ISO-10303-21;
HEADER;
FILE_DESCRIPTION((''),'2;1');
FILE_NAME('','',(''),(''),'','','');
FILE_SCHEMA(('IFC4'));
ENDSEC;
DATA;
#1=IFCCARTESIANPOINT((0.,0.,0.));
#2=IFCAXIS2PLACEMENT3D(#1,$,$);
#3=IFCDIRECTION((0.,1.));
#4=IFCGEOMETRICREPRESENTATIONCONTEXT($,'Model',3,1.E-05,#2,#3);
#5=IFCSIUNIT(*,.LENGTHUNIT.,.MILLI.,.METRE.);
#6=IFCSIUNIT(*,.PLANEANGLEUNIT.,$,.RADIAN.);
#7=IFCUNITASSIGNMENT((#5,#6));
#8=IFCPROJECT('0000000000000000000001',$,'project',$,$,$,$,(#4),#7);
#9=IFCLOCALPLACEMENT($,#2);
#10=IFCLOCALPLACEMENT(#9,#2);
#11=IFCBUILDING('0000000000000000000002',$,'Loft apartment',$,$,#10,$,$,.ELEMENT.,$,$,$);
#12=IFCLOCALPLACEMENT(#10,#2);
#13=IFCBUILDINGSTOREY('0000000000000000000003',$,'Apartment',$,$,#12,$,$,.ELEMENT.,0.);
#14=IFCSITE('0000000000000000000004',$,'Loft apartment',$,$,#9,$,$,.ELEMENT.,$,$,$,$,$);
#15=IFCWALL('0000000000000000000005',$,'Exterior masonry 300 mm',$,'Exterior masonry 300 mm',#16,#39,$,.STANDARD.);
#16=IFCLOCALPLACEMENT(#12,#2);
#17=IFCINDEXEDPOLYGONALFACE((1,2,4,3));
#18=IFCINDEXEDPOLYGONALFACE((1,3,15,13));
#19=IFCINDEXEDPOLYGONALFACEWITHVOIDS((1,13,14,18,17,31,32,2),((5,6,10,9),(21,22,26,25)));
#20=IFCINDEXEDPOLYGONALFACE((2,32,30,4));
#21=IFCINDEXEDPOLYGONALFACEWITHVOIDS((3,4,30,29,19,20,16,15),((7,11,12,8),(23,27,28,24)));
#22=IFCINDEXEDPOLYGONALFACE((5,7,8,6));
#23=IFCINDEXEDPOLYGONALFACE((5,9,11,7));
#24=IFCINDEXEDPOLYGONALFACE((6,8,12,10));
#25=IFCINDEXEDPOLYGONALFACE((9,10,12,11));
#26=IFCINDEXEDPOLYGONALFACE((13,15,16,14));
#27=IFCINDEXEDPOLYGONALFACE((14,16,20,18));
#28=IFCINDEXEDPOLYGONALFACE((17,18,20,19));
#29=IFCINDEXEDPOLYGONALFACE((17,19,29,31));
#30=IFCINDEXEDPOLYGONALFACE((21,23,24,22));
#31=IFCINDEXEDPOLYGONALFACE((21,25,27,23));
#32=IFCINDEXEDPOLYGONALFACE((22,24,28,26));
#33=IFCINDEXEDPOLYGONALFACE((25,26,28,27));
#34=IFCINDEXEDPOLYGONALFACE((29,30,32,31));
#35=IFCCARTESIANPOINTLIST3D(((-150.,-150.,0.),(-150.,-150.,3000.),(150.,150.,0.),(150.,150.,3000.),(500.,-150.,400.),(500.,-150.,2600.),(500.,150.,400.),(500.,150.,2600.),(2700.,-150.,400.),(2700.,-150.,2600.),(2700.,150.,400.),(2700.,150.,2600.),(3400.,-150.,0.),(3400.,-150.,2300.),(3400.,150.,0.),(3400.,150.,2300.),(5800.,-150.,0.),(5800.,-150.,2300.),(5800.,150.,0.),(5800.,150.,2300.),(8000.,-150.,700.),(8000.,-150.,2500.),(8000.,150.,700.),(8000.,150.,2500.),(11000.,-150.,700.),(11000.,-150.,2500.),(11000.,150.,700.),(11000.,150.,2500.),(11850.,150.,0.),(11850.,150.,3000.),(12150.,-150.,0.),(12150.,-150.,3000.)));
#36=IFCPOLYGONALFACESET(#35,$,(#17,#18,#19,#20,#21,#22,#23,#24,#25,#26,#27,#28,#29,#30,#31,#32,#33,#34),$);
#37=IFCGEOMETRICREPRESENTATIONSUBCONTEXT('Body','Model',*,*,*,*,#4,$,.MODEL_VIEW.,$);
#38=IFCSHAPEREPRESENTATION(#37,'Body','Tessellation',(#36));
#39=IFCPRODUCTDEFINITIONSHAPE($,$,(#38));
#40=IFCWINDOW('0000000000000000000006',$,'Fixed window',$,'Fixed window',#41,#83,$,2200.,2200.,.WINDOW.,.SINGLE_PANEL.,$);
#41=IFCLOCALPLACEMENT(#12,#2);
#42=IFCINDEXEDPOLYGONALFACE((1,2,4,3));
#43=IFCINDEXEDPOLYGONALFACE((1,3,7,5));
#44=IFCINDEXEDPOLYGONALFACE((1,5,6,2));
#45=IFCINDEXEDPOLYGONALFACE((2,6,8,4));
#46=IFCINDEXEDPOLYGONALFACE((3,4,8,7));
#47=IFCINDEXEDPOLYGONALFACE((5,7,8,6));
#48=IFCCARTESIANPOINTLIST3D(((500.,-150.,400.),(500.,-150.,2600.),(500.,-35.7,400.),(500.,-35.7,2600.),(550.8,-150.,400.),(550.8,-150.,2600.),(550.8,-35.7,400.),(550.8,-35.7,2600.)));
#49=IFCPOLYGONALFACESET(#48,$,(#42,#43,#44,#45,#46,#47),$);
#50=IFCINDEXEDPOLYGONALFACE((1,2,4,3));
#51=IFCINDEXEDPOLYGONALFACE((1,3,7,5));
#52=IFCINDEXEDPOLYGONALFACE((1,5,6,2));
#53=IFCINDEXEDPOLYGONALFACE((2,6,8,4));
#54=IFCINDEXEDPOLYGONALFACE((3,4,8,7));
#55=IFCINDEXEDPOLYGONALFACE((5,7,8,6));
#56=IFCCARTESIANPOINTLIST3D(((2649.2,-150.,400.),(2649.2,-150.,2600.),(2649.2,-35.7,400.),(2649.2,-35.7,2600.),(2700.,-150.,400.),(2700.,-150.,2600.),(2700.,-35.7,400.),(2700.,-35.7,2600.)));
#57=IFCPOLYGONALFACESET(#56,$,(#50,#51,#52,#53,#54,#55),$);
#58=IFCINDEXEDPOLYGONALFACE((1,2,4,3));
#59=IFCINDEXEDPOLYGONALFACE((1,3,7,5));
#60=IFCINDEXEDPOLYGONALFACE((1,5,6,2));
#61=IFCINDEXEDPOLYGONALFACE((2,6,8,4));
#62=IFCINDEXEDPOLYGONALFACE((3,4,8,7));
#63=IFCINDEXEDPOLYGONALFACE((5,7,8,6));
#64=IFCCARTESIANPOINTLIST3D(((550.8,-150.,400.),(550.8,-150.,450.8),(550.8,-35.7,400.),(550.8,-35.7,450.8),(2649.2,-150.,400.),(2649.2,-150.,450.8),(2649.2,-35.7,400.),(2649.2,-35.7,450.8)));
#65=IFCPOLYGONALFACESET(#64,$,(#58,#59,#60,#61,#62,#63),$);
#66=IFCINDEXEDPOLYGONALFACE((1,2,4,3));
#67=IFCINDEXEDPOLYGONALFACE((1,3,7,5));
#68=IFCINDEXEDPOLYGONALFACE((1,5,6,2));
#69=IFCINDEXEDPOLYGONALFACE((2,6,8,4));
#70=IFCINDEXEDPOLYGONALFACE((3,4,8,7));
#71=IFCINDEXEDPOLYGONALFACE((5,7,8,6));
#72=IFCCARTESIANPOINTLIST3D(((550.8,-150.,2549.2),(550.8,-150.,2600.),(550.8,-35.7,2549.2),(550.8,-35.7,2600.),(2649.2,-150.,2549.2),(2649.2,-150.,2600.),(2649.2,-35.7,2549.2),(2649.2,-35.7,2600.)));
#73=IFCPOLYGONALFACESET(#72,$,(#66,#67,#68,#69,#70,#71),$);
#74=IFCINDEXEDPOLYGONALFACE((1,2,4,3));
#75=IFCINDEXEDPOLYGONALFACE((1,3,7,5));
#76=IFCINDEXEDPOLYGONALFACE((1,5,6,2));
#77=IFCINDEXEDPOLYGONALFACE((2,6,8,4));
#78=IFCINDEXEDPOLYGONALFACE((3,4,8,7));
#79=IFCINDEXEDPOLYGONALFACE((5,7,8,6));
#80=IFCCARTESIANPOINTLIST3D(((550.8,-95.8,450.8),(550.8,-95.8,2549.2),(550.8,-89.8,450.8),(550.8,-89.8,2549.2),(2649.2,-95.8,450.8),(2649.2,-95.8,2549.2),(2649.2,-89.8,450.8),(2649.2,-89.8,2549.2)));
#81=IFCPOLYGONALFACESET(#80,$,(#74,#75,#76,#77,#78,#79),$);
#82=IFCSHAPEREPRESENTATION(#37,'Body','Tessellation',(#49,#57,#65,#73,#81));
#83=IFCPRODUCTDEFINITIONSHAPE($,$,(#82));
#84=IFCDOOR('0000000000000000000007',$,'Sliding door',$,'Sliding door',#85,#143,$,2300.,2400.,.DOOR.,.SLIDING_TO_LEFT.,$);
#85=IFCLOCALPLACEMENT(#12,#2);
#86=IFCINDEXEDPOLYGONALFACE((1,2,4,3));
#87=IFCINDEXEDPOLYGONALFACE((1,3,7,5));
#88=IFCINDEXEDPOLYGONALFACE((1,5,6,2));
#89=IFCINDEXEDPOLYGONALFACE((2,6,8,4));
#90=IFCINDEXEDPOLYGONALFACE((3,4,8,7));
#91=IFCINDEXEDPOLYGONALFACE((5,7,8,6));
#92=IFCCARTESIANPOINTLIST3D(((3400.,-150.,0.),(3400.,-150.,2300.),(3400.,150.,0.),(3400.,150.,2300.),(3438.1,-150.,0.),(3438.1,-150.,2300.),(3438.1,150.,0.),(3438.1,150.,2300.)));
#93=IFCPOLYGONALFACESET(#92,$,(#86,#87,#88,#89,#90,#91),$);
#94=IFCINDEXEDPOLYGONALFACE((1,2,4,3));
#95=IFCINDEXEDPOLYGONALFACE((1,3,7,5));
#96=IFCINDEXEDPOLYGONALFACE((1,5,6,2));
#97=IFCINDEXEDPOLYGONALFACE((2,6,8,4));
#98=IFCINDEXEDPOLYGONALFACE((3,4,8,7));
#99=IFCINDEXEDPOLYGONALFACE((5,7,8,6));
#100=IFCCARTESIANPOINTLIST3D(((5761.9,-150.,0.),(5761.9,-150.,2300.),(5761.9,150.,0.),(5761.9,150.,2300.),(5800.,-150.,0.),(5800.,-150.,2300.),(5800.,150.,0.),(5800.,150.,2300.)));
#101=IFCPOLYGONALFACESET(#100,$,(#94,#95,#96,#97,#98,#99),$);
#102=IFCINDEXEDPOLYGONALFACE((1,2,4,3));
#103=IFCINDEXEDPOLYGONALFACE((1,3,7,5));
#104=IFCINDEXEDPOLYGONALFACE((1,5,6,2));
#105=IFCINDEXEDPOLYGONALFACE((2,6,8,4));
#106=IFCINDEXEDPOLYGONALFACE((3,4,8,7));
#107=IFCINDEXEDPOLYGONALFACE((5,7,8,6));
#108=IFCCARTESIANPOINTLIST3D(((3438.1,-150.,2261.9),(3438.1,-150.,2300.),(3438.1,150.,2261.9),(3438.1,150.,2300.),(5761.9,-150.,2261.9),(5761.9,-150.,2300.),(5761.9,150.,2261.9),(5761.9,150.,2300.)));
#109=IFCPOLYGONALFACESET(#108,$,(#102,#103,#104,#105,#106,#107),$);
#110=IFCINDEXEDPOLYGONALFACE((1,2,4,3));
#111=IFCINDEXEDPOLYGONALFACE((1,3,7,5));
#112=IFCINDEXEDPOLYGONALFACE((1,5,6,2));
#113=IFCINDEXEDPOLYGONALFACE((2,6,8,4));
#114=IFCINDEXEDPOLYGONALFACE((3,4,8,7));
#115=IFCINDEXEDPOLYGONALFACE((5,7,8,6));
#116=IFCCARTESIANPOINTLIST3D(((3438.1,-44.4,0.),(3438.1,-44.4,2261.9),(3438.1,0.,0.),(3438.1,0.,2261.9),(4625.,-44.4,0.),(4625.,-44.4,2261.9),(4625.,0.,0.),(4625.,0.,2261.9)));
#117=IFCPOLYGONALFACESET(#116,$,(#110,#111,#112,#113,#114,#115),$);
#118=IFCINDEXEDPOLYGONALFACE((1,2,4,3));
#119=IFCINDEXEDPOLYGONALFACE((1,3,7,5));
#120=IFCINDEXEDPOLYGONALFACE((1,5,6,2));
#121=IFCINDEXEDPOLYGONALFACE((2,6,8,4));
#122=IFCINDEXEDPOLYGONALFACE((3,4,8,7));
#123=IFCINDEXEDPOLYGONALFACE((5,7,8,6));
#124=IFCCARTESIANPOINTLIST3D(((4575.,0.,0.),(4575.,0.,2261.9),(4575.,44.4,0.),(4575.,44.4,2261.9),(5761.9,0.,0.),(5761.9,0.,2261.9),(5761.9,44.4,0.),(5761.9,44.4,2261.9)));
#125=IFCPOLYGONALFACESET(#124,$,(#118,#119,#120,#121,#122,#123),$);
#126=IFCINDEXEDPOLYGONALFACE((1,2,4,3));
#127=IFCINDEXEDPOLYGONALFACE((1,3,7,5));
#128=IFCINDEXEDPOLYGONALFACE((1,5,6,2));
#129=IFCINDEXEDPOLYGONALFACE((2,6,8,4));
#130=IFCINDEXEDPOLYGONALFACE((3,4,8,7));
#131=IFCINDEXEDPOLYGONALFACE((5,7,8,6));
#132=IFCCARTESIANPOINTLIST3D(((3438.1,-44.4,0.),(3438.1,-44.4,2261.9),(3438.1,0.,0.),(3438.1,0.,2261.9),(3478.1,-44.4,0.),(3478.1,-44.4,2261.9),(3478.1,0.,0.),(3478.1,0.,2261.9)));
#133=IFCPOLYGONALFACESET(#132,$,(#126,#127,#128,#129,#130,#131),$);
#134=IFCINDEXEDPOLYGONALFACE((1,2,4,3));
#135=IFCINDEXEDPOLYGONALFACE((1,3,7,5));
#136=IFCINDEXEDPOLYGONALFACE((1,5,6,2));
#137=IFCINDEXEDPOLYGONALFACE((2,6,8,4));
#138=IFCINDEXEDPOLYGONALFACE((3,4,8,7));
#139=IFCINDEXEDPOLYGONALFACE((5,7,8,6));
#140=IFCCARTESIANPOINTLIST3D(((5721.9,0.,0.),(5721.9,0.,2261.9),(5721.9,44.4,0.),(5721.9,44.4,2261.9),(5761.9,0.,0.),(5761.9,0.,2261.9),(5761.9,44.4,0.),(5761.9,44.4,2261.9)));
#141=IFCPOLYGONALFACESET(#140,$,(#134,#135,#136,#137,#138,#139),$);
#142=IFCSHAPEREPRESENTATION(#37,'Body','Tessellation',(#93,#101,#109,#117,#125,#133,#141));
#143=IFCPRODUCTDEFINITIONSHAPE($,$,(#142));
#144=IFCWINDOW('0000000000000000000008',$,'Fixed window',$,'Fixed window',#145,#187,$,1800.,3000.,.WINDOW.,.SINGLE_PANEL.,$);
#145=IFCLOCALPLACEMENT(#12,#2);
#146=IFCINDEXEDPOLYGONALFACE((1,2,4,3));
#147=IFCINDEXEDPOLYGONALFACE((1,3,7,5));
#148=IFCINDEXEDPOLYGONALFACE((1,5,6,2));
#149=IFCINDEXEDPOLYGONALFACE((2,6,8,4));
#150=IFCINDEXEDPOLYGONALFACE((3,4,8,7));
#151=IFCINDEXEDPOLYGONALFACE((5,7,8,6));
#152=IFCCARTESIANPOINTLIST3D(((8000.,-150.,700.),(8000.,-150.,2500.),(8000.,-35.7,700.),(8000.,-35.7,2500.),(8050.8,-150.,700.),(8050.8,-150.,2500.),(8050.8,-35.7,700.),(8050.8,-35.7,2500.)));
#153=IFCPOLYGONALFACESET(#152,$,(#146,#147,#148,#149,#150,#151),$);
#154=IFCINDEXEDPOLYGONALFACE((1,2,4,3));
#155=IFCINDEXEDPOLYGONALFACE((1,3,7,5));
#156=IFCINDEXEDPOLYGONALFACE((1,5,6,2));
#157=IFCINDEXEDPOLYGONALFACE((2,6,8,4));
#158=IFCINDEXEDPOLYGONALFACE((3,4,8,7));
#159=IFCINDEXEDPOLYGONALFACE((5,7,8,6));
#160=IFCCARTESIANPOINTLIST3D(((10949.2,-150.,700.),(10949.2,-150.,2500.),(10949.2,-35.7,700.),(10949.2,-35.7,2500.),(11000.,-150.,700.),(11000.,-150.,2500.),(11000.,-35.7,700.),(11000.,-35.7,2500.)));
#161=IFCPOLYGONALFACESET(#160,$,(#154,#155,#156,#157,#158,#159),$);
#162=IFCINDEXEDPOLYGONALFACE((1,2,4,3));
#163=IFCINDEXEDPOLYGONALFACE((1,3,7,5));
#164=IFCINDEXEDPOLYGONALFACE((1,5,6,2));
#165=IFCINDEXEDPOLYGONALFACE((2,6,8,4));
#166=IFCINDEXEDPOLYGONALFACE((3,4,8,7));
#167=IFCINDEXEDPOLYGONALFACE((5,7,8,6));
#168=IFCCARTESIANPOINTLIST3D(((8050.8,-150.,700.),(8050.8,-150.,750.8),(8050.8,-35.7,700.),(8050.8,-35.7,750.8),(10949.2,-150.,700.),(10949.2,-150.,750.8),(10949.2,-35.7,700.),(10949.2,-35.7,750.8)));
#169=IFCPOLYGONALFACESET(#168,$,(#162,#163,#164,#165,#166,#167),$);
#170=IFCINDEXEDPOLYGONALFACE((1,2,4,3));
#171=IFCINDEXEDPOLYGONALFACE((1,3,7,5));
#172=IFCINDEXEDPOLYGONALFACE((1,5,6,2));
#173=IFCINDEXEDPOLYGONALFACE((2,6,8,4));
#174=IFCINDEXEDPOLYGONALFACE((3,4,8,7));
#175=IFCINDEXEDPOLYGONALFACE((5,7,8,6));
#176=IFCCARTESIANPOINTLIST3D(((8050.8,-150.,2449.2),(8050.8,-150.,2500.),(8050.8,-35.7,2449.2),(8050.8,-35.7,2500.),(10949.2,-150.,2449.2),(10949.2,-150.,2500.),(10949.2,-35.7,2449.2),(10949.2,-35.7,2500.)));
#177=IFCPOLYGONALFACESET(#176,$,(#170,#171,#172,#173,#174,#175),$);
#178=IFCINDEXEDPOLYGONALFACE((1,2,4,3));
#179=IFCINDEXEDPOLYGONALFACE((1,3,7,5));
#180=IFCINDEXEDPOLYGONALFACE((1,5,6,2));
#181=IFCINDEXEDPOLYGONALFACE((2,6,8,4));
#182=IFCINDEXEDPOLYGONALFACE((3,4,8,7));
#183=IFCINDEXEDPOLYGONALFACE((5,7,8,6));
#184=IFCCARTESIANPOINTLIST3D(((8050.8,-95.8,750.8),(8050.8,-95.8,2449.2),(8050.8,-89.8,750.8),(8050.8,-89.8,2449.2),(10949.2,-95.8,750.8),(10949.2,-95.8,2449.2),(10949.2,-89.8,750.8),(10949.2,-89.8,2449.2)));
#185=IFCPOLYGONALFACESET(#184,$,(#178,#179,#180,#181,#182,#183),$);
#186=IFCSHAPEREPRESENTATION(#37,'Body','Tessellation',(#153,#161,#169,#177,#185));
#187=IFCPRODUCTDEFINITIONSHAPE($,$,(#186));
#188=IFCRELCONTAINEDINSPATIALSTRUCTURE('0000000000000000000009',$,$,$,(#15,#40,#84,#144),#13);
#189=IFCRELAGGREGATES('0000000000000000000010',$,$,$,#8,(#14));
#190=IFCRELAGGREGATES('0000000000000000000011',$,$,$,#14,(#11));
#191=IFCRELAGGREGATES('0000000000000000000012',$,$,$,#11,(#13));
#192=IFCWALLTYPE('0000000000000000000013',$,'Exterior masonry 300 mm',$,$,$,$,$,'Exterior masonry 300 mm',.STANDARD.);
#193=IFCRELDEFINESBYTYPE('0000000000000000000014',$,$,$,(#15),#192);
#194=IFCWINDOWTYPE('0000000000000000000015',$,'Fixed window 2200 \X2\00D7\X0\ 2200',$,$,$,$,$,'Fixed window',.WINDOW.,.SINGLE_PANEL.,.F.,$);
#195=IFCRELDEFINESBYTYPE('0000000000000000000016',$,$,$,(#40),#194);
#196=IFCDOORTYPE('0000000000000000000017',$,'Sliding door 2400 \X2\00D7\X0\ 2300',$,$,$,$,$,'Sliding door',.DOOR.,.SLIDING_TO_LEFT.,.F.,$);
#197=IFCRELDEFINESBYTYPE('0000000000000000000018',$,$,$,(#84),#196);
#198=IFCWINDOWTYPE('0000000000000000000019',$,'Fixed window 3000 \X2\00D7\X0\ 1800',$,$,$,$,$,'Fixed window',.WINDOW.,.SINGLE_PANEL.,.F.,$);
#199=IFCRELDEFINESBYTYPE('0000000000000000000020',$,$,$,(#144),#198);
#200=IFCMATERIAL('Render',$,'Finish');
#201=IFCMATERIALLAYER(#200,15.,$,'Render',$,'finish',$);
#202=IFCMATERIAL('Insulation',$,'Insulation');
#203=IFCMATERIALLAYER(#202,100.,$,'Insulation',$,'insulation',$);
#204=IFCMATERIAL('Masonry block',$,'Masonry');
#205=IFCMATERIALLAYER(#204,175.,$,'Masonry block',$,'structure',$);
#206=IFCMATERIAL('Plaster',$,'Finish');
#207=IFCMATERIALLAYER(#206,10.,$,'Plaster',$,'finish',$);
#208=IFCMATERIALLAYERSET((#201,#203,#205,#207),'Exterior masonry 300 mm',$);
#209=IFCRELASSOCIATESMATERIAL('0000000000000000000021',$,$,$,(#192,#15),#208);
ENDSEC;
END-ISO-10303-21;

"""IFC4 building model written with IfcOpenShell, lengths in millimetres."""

from ifc_helpers import new_model, si_unit, direction, frame, origin, origin_with_axes, place, context, subcontext, project, spatial, polyline, outline, extrude, material, layer, layer_set, layer_usage, type_object, element, fill, save


model = new_model("IFC4")

# Units and contexts
model_context = context("Model", 3, precision=1e-05, world=origin(), true_north=direction((0.0, 1.0)))
body_context = subcontext(model_context, "Body", "Model", "MODEL_VIEW")
ifc_project = project(units=[si_unit("LENGTHUNIT", "METRE", prefix="MILLI"), si_unit("PLANEANGLEUNIT", "RADIAN")], contexts=[model_context])

# Site, building, storey
site_placement = place(None, origin())
site = spatial("IfcSite", under=ifc_project, at=site_placement, Name="Loft apartment", CompositionType="ELEMENT")
building_placement = place(site_placement, origin())
building = spatial("IfcBuilding", under=site, at=building_placement, Name="Loft apartment", CompositionType="ELEMENT")
storey_placement = place(building_placement, origin())
storey = spatial("IfcBuildingStorey", under=building, at=storey_placement, Name="Apartment", CompositionType="ELEMENT", Elevation=0.0)

# Wall, openings, windows, door
ifc_material_1 = material(Name="Render", Category="Finish")
ifc_layer_1 = layer(ifc_material_1, 15.0, Name="Render", Category="finish")
ifc_material_2 = material(Name="Insulation", Category="Insulation")
ifc_layer_2 = layer(ifc_material_2, 100.0, Name="Insulation", Category="insulation")
ifc_material_3 = material(Name="Masonry block", Category="Masonry")
ifc_layer_3 = layer(ifc_material_3, 175.0, Name="Masonry block", Category="structure")
ifc_material_4 = material(Name="Plaster", Category="Finish")
ifc_layer_4 = layer(ifc_material_4, 10.0, Name="Plaster", Category="finish")
ifc_layer_set_1 = layer_set([ifc_layer_1, ifc_layer_2, ifc_layer_3, ifc_layer_4], Name="Exterior masonry 300 mm")
ifc_layer_usage_1 = layer_usage(ifc_layer_set_1, "AXIS2", "POSITIVE", -150.0)
wall_type_1 = type_object("IfcWallType", Name="Exterior masonry 300 mm", ElementType="Exterior masonry 300 mm", PredefinedType="STANDARD", material=ifc_layer_set_1)
wall_1_placement = place(storey_placement, origin_with_axes())
wall_1 = element("IfcWall", 1, at=wall_1_placement, inside=storey, type_object=wall_type_1, material=ifc_layer_usage_1, Name="Exterior masonry 300 mm", ObjectType="Exterior masonry 300 mm", PredefinedType="STANDARD", context=body_context, shape_type="SweptSolid", body=[
    extrude(outline(polyline([(-150.0, -150.0), (12150.0, -150.0), (11850.0, 150.0), (150.0, 150.0), (-150.0, -150.0)])), origin(), (0.0, 0.0, 1.0), 3000.0),
])
opening_1_placement = place(wall_1_placement, frame((500.0, 0.0, 400.0), z_axis=(0.0, 0.0, 1.0), x_axis=(1.0, 0.0, 0.0)))
opening_1 = element("IfcOpeningElement", 2, at=opening_1_placement, cuts=wall_1, PredefinedType="OPENING", context=body_context, shape_type="SweptSolid", body=[
    extrude(outline(polyline([(0.0, -160.0), (2200.0, -160.0), (2200.0, 160.0), (0.0, 160.0), (0.0, -160.0)])), origin(), (0.0, 0.0, 1.0), 2200.0),
])
opening_2_placement = place(wall_1_placement, frame((3400.0, 0.0, 0.0), z_axis=(0.0, 0.0, 1.0), x_axis=(1.0, 0.0, 0.0)))
opening_2 = element("IfcOpeningElement", 3, at=opening_2_placement, cuts=wall_1, PredefinedType="OPENING", context=body_context, shape_type="SweptSolid", body=[
    extrude(outline(polyline([(0.0, -160.0), (2400.0, -160.0), (2400.0, 160.0), (0.0, 160.0), (0.0, -160.0)])), origin(), (0.0, 0.0, 1.0), 2300.0),
])
opening_3_placement = place(wall_1_placement, frame((8000.0, 0.0, 700.0), z_axis=(0.0, 0.0, 1.0), x_axis=(1.0, 0.0, 0.0)))
opening_3 = element("IfcOpeningElement", 4, at=opening_3_placement, cuts=wall_1, PredefinedType="OPENING", context=body_context, shape_type="SweptSolid", body=[
    extrude(outline(polyline([(0.0, -160.0), (3000.0, -160.0), (3000.0, 160.0), (0.0, 160.0), (0.0, -160.0)])), origin(), (0.0, 0.0, 1.0), 1800.0),
])
window_type_1 = type_object("IfcWindowType", Name="Fixed window 2200 × 2200", ElementType="Fixed window", ParameterTakesPrecedence=False, PartitioningType="SINGLE_PANEL", PredefinedType="WINDOW")
window_1_placement = place(opening_1_placement, origin_with_axes())
window_1 = element("IfcWindow", 5, at=window_1_placement, inside=storey, type_object=window_type_1, Name="Fixed window", ObjectType="Fixed window", OverallHeight=2200.0, OverallWidth=2200.0, PartitioningType="SINGLE_PANEL", PredefinedType="WINDOW", context=body_context, shape_type="SweptSolid", body=[
    extrude(outline(polyline([(0.0, -150.0), (50.8, -150.0), (50.8, -35.7), (0.0, -35.7), (0.0, -150.0)])), origin(), (0.0, 0.0, 1.0), 2200.0),
    extrude(outline(polyline([(2149.2, -150.0), (2200.0, -150.0), (2200.0, -35.7), (2149.2, -35.7), (2149.2, -150.0)])), origin(), (0.0, 0.0, 1.0), 2200.0),
    extrude(outline(polyline([(50.8, -150.0), (2149.2, -150.0), (2149.2, -35.7), (50.8, -35.7), (50.8, -150.0)])), origin(), (0.0, 0.0, 1.0), 50.8),
    extrude(outline(polyline([(50.8, -150.0), (2149.2, -150.0), (2149.2, -35.7), (50.8, -35.7), (50.8, -150.0)])), frame((0.0, 0.0, 2149.2)), (0.0, 0.0, 1.0), 50.8),
    extrude(outline(polyline([(50.8, -95.8), (2149.2, -95.8), (2149.2, -89.8), (50.8, -89.8), (50.8, -95.8)])), frame((0.0, 0.0, 50.8)), (0.0, 0.0, 1.0), 2098.4),
])
fill(opening_1, window_1)
door_type_1 = type_object("IfcDoorType", Name="Sliding door 2400 × 2300", ElementType="Sliding door", OperationType="SLIDING_TO_LEFT", ParameterTakesPrecedence=False, PredefinedType="DOOR")
door_1_placement = place(opening_2_placement, origin_with_axes())
door_1 = element("IfcDoor", 6, at=door_1_placement, inside=storey, type_object=door_type_1, Name="Sliding door", ObjectType="Sliding door", OperationType="SLIDING_TO_LEFT", OverallHeight=2300.0, OverallWidth=2400.0, PredefinedType="DOOR", context=body_context, shape_type="SweptSolid", body=[
    extrude(outline(polyline([(0.0, -150.0), (38.1, -150.0), (38.1, 150.0), (0.0, 150.0), (0.0, -150.0)])), origin(), (0.0, 0.0, 1.0), 2300.0),
    extrude(outline(polyline([(2361.9, -150.0), (2400.0, -150.0), (2400.0, 150.0), (2361.9, 150.0), (2361.9, -150.0)])), origin(), (0.0, 0.0, 1.0), 2300.0),
    extrude(outline(polyline([(38.1, -150.0), (2361.9, -150.0), (2361.9, 150.0), (38.1, 150.0), (38.1, -150.0)])), frame((0.0, 0.0, 2261.9)), (0.0, 0.0, 1.0), 38.1),
    extrude(outline(polyline([(38.1, -44.5), (1225.0, -44.5), (1225.0, 0.0), (38.1, 0.0), (38.1, -44.5)])), origin(), (0.0, 0.0, 1.0), 2261.9),
    extrude(outline(polyline([(1175.0, 0.0), (2361.9, 0.0), (2361.9, 44.5), (1175.0, 44.5), (1175.0, 0.0)])), origin(), (0.0, 0.0, 1.0), 2261.9),
    extrude(outline(polyline([(38.1, -44.5), (78.1, -44.5), (78.1, 0.0), (38.1, 0.0), (38.1, -44.5)])), origin(), (0.0, 0.0, 1.0), 2261.9),
    extrude(outline(polyline([(2321.9, 0.0), (2361.9, 0.0), (2361.9, 44.5), (2321.9, 44.5), (2321.9, 0.0)])), origin(), (0.0, 0.0, 1.0), 2261.9),
])
fill(opening_2, door_1)
window_type_2 = type_object("IfcWindowType", Name="Fixed window 3000 × 1800", ElementType="Fixed window", ParameterTakesPrecedence=False, PartitioningType="SINGLE_PANEL", PredefinedType="WINDOW")
window_2_placement = place(opening_3_placement, origin_with_axes())
window_2 = element("IfcWindow", 7, at=window_2_placement, inside=storey, type_object=window_type_2, Name="Fixed window", ObjectType="Fixed window", OverallHeight=1800.0, OverallWidth=3000.0, PartitioningType="SINGLE_PANEL", PredefinedType="WINDOW", context=body_context, shape_type="SweptSolid", body=[
    extrude(outline(polyline([(0.0, -150.0), (50.8, -150.0), (50.8, -35.7), (0.0, -35.7), (0.0, -150.0)])), origin(), (0.0, 0.0, 1.0), 1800.0),
    extrude(outline(polyline([(2949.2, -150.0), (3000.0, -150.0), (3000.0, -35.7), (2949.2, -35.7), (2949.2, -150.0)])), origin(), (0.0, 0.0, 1.0), 1800.0),
    extrude(outline(polyline([(50.8, -150.0), (2949.2, -150.0), (2949.2, -35.7), (50.8, -35.7), (50.8, -150.0)])), origin(), (0.0, 0.0, 1.0), 50.8),
    extrude(outline(polyline([(50.8, -150.0), (2949.2, -150.0), (2949.2, -35.7), (50.8, -35.7), (50.8, -150.0)])), frame((0.0, 0.0, 1749.2)), (0.0, 0.0, 1.0), 50.8),
    extrude(outline(polyline([(50.8, -95.8), (2949.2, -95.8), (2949.2, -89.8), (50.8, -89.8), (50.8, -95.8)])), frame((0.0, 0.0, 50.8)), (0.0, 0.0, 1.0), 1698.4),
])
fill(opening_3, window_2)

save(model, "model.ifc")
